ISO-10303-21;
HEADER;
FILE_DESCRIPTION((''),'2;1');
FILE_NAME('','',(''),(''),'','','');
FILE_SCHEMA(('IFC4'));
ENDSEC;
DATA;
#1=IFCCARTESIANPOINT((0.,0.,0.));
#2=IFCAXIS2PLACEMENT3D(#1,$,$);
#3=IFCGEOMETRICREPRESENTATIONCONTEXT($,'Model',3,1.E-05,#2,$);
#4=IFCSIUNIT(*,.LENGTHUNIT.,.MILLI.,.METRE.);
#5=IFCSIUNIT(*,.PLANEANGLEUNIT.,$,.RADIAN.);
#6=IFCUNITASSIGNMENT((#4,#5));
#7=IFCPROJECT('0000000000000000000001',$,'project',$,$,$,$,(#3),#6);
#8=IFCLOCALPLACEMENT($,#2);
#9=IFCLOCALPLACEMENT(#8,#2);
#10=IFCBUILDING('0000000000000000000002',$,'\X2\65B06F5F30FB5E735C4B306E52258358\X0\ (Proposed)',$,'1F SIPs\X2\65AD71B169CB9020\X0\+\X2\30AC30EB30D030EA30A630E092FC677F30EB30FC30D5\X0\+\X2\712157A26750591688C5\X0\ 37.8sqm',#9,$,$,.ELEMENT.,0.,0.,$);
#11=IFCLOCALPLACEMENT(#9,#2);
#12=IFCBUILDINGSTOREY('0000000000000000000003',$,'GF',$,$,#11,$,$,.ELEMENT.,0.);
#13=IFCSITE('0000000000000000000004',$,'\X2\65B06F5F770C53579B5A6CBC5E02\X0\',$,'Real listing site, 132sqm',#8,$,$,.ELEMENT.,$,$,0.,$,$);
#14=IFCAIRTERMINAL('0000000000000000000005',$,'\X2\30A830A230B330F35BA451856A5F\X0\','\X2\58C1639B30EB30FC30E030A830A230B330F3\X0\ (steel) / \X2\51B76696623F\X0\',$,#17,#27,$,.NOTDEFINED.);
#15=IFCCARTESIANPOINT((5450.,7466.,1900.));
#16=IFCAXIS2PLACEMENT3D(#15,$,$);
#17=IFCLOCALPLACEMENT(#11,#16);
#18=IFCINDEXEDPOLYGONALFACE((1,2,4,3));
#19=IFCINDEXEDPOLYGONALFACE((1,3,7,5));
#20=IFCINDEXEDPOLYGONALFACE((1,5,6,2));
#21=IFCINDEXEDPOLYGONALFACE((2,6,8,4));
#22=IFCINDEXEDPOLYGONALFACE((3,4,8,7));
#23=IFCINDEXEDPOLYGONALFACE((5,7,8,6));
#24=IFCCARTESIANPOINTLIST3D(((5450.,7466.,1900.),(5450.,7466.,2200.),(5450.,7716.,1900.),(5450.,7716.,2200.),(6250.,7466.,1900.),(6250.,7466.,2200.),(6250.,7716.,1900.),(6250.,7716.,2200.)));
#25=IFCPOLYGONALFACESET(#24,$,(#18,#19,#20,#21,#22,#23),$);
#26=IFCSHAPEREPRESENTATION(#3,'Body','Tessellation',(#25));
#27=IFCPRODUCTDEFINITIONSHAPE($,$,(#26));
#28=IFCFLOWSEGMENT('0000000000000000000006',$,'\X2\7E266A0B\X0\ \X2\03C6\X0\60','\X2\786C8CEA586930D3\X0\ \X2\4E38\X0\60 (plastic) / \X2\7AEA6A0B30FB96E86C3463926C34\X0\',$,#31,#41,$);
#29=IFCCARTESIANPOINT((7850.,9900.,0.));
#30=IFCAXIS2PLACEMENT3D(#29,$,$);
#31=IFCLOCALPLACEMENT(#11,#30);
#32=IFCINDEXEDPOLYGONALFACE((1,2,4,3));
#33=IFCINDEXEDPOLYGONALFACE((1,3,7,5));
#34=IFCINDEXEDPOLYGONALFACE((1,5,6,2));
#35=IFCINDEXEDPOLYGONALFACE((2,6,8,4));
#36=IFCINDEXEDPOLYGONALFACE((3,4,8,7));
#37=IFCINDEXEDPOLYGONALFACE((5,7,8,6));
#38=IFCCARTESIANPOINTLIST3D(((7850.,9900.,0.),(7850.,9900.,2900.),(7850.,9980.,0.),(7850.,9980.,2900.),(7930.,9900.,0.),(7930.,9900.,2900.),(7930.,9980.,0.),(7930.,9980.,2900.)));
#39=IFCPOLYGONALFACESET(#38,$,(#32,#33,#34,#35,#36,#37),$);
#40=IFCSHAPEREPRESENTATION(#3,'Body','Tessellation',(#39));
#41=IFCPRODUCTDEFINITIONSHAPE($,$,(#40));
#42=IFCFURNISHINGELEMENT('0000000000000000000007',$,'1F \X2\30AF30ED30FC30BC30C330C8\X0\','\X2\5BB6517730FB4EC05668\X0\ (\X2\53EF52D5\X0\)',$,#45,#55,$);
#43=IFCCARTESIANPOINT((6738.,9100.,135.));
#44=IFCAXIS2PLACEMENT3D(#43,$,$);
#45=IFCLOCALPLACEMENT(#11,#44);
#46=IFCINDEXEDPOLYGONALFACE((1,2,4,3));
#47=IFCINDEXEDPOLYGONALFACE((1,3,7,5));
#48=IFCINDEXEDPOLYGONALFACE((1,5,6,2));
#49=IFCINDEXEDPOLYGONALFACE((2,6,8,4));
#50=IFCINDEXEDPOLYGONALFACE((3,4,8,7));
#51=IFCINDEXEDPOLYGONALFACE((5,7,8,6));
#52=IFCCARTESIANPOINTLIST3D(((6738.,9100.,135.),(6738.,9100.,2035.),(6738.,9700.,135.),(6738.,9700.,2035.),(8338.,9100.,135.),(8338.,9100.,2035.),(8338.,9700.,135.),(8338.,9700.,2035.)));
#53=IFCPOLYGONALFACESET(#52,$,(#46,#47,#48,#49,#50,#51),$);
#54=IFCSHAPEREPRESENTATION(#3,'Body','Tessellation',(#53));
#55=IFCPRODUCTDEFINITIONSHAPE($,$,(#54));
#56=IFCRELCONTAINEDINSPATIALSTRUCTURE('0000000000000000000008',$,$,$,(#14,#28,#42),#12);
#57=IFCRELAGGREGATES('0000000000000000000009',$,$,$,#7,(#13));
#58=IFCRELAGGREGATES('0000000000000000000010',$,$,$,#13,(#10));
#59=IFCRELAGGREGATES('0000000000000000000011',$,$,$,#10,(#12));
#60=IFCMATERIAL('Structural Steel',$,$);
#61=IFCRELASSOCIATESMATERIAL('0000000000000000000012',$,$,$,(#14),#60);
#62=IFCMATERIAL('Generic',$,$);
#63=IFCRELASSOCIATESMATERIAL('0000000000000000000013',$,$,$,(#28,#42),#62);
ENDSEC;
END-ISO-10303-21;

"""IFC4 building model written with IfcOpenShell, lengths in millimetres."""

from ifc_helpers import new_model, si_unit, frame, frame_2d, origin, place, context, project, spatial, rectangle, extrude, material, element, save


model = new_model("IFC4")

# Units and contexts
model_context = context("Model", 3, precision=1e-05, world=origin())
ifc_project = project(units=[si_unit("LENGTHUNIT", "METRE", prefix="MILLI"), si_unit("PLANEANGLEUNIT", "RADIAN")], contexts=[model_context])

# Site, building, storey
site_placement = place(None, origin())
site = spatial("IfcSite", under=ifc_project, at=site_placement, Name="新潟県南魚沼市", ObjectType="Real listing site, 132sqm", CompositionType="ELEMENT", RefElevation=0.0)
building_placement = place(site_placement, origin())
building = spatial("IfcBuilding", under=site, at=building_placement, Name="新潟・平屋の別荘 (Proposed)", ObjectType="1F SIPs断熱構造+ガルバリウム鋼板ルーフ+無垢材外装 37.8sqm", CompositionType="ELEMENT", ElevationOfRefHeight=0.0, ElevationOfTerrain=0.0)
storey_placement = place(building_placement, origin())
storey = spatial("IfcBuildingStorey", under=building, at=storey_placement, Name="GF", CompositionType="ELEMENT", Elevation=0.0)

# Shared definitions
ifc_material_1 = material(Name="Structural Steel")

# Shared definitions
ifc_material_2 = material(Name="Generic")

# Air terminal
air_terminal_placement = place(storey_placement, frame((5450.0, 7466.0, 1900.0)))
element("IfcAirTerminal", 1, at=air_terminal_placement, inside=storey, material=ifc_material_1, Name="エアコン室内機", Description="壁掛ルームエアコン (steel) / 冷暖房", PredefinedType="NOTDEFINED", context=model_context, shape_type="SweptSolid", body=[
    extrude(rectangle(XDim=800.0, YDim=250.0, at=frame_2d((400.0, 125.0))), frame((5450.0, 7466.0, 1900.0)), (0.0, 0.0, 1.0), 300.0),
])

# Flow segment
flow_segment_placement = place(storey_placement, frame((7850.0, 9900.0, 0.0)))
element("IfcFlowSegment", 2, at=flow_segment_placement, inside=storey, material=ifc_material_2, Name="縦樋 φ60", Description="硬質塩ビ 丸60 (plastic) / 竪樋・雨水排水", context=model_context, shape_type="SweptSolid", body=[
    extrude(rectangle(XDim=80.0, YDim=80.0, at=frame_2d((40.0, 40.0))), frame((7850.0, 9900.0, 0.0)), (0.0, 0.0, 1.0), 2900.0),
])

# Furnishing element
furnishing_placement = place(storey_placement, frame((6738.0, 9100.0, 135.0)))
element("IfcFurnishingElement", 3, at=furnishing_placement, inside=storey, material=ifc_material_2, Name="1F クローゼット", Description="家具・什器 (可動)", context=model_context, shape_type="SweptSolid", body=[
    extrude(rectangle(XDim=1600.0, YDim=600.0, at=frame_2d((800.0, 300.0))), frame((6738.0, 9100.0, 135.0)), (0.0, 0.0, 1.0), 1900.0),
])

save(model, "model.ifc")
